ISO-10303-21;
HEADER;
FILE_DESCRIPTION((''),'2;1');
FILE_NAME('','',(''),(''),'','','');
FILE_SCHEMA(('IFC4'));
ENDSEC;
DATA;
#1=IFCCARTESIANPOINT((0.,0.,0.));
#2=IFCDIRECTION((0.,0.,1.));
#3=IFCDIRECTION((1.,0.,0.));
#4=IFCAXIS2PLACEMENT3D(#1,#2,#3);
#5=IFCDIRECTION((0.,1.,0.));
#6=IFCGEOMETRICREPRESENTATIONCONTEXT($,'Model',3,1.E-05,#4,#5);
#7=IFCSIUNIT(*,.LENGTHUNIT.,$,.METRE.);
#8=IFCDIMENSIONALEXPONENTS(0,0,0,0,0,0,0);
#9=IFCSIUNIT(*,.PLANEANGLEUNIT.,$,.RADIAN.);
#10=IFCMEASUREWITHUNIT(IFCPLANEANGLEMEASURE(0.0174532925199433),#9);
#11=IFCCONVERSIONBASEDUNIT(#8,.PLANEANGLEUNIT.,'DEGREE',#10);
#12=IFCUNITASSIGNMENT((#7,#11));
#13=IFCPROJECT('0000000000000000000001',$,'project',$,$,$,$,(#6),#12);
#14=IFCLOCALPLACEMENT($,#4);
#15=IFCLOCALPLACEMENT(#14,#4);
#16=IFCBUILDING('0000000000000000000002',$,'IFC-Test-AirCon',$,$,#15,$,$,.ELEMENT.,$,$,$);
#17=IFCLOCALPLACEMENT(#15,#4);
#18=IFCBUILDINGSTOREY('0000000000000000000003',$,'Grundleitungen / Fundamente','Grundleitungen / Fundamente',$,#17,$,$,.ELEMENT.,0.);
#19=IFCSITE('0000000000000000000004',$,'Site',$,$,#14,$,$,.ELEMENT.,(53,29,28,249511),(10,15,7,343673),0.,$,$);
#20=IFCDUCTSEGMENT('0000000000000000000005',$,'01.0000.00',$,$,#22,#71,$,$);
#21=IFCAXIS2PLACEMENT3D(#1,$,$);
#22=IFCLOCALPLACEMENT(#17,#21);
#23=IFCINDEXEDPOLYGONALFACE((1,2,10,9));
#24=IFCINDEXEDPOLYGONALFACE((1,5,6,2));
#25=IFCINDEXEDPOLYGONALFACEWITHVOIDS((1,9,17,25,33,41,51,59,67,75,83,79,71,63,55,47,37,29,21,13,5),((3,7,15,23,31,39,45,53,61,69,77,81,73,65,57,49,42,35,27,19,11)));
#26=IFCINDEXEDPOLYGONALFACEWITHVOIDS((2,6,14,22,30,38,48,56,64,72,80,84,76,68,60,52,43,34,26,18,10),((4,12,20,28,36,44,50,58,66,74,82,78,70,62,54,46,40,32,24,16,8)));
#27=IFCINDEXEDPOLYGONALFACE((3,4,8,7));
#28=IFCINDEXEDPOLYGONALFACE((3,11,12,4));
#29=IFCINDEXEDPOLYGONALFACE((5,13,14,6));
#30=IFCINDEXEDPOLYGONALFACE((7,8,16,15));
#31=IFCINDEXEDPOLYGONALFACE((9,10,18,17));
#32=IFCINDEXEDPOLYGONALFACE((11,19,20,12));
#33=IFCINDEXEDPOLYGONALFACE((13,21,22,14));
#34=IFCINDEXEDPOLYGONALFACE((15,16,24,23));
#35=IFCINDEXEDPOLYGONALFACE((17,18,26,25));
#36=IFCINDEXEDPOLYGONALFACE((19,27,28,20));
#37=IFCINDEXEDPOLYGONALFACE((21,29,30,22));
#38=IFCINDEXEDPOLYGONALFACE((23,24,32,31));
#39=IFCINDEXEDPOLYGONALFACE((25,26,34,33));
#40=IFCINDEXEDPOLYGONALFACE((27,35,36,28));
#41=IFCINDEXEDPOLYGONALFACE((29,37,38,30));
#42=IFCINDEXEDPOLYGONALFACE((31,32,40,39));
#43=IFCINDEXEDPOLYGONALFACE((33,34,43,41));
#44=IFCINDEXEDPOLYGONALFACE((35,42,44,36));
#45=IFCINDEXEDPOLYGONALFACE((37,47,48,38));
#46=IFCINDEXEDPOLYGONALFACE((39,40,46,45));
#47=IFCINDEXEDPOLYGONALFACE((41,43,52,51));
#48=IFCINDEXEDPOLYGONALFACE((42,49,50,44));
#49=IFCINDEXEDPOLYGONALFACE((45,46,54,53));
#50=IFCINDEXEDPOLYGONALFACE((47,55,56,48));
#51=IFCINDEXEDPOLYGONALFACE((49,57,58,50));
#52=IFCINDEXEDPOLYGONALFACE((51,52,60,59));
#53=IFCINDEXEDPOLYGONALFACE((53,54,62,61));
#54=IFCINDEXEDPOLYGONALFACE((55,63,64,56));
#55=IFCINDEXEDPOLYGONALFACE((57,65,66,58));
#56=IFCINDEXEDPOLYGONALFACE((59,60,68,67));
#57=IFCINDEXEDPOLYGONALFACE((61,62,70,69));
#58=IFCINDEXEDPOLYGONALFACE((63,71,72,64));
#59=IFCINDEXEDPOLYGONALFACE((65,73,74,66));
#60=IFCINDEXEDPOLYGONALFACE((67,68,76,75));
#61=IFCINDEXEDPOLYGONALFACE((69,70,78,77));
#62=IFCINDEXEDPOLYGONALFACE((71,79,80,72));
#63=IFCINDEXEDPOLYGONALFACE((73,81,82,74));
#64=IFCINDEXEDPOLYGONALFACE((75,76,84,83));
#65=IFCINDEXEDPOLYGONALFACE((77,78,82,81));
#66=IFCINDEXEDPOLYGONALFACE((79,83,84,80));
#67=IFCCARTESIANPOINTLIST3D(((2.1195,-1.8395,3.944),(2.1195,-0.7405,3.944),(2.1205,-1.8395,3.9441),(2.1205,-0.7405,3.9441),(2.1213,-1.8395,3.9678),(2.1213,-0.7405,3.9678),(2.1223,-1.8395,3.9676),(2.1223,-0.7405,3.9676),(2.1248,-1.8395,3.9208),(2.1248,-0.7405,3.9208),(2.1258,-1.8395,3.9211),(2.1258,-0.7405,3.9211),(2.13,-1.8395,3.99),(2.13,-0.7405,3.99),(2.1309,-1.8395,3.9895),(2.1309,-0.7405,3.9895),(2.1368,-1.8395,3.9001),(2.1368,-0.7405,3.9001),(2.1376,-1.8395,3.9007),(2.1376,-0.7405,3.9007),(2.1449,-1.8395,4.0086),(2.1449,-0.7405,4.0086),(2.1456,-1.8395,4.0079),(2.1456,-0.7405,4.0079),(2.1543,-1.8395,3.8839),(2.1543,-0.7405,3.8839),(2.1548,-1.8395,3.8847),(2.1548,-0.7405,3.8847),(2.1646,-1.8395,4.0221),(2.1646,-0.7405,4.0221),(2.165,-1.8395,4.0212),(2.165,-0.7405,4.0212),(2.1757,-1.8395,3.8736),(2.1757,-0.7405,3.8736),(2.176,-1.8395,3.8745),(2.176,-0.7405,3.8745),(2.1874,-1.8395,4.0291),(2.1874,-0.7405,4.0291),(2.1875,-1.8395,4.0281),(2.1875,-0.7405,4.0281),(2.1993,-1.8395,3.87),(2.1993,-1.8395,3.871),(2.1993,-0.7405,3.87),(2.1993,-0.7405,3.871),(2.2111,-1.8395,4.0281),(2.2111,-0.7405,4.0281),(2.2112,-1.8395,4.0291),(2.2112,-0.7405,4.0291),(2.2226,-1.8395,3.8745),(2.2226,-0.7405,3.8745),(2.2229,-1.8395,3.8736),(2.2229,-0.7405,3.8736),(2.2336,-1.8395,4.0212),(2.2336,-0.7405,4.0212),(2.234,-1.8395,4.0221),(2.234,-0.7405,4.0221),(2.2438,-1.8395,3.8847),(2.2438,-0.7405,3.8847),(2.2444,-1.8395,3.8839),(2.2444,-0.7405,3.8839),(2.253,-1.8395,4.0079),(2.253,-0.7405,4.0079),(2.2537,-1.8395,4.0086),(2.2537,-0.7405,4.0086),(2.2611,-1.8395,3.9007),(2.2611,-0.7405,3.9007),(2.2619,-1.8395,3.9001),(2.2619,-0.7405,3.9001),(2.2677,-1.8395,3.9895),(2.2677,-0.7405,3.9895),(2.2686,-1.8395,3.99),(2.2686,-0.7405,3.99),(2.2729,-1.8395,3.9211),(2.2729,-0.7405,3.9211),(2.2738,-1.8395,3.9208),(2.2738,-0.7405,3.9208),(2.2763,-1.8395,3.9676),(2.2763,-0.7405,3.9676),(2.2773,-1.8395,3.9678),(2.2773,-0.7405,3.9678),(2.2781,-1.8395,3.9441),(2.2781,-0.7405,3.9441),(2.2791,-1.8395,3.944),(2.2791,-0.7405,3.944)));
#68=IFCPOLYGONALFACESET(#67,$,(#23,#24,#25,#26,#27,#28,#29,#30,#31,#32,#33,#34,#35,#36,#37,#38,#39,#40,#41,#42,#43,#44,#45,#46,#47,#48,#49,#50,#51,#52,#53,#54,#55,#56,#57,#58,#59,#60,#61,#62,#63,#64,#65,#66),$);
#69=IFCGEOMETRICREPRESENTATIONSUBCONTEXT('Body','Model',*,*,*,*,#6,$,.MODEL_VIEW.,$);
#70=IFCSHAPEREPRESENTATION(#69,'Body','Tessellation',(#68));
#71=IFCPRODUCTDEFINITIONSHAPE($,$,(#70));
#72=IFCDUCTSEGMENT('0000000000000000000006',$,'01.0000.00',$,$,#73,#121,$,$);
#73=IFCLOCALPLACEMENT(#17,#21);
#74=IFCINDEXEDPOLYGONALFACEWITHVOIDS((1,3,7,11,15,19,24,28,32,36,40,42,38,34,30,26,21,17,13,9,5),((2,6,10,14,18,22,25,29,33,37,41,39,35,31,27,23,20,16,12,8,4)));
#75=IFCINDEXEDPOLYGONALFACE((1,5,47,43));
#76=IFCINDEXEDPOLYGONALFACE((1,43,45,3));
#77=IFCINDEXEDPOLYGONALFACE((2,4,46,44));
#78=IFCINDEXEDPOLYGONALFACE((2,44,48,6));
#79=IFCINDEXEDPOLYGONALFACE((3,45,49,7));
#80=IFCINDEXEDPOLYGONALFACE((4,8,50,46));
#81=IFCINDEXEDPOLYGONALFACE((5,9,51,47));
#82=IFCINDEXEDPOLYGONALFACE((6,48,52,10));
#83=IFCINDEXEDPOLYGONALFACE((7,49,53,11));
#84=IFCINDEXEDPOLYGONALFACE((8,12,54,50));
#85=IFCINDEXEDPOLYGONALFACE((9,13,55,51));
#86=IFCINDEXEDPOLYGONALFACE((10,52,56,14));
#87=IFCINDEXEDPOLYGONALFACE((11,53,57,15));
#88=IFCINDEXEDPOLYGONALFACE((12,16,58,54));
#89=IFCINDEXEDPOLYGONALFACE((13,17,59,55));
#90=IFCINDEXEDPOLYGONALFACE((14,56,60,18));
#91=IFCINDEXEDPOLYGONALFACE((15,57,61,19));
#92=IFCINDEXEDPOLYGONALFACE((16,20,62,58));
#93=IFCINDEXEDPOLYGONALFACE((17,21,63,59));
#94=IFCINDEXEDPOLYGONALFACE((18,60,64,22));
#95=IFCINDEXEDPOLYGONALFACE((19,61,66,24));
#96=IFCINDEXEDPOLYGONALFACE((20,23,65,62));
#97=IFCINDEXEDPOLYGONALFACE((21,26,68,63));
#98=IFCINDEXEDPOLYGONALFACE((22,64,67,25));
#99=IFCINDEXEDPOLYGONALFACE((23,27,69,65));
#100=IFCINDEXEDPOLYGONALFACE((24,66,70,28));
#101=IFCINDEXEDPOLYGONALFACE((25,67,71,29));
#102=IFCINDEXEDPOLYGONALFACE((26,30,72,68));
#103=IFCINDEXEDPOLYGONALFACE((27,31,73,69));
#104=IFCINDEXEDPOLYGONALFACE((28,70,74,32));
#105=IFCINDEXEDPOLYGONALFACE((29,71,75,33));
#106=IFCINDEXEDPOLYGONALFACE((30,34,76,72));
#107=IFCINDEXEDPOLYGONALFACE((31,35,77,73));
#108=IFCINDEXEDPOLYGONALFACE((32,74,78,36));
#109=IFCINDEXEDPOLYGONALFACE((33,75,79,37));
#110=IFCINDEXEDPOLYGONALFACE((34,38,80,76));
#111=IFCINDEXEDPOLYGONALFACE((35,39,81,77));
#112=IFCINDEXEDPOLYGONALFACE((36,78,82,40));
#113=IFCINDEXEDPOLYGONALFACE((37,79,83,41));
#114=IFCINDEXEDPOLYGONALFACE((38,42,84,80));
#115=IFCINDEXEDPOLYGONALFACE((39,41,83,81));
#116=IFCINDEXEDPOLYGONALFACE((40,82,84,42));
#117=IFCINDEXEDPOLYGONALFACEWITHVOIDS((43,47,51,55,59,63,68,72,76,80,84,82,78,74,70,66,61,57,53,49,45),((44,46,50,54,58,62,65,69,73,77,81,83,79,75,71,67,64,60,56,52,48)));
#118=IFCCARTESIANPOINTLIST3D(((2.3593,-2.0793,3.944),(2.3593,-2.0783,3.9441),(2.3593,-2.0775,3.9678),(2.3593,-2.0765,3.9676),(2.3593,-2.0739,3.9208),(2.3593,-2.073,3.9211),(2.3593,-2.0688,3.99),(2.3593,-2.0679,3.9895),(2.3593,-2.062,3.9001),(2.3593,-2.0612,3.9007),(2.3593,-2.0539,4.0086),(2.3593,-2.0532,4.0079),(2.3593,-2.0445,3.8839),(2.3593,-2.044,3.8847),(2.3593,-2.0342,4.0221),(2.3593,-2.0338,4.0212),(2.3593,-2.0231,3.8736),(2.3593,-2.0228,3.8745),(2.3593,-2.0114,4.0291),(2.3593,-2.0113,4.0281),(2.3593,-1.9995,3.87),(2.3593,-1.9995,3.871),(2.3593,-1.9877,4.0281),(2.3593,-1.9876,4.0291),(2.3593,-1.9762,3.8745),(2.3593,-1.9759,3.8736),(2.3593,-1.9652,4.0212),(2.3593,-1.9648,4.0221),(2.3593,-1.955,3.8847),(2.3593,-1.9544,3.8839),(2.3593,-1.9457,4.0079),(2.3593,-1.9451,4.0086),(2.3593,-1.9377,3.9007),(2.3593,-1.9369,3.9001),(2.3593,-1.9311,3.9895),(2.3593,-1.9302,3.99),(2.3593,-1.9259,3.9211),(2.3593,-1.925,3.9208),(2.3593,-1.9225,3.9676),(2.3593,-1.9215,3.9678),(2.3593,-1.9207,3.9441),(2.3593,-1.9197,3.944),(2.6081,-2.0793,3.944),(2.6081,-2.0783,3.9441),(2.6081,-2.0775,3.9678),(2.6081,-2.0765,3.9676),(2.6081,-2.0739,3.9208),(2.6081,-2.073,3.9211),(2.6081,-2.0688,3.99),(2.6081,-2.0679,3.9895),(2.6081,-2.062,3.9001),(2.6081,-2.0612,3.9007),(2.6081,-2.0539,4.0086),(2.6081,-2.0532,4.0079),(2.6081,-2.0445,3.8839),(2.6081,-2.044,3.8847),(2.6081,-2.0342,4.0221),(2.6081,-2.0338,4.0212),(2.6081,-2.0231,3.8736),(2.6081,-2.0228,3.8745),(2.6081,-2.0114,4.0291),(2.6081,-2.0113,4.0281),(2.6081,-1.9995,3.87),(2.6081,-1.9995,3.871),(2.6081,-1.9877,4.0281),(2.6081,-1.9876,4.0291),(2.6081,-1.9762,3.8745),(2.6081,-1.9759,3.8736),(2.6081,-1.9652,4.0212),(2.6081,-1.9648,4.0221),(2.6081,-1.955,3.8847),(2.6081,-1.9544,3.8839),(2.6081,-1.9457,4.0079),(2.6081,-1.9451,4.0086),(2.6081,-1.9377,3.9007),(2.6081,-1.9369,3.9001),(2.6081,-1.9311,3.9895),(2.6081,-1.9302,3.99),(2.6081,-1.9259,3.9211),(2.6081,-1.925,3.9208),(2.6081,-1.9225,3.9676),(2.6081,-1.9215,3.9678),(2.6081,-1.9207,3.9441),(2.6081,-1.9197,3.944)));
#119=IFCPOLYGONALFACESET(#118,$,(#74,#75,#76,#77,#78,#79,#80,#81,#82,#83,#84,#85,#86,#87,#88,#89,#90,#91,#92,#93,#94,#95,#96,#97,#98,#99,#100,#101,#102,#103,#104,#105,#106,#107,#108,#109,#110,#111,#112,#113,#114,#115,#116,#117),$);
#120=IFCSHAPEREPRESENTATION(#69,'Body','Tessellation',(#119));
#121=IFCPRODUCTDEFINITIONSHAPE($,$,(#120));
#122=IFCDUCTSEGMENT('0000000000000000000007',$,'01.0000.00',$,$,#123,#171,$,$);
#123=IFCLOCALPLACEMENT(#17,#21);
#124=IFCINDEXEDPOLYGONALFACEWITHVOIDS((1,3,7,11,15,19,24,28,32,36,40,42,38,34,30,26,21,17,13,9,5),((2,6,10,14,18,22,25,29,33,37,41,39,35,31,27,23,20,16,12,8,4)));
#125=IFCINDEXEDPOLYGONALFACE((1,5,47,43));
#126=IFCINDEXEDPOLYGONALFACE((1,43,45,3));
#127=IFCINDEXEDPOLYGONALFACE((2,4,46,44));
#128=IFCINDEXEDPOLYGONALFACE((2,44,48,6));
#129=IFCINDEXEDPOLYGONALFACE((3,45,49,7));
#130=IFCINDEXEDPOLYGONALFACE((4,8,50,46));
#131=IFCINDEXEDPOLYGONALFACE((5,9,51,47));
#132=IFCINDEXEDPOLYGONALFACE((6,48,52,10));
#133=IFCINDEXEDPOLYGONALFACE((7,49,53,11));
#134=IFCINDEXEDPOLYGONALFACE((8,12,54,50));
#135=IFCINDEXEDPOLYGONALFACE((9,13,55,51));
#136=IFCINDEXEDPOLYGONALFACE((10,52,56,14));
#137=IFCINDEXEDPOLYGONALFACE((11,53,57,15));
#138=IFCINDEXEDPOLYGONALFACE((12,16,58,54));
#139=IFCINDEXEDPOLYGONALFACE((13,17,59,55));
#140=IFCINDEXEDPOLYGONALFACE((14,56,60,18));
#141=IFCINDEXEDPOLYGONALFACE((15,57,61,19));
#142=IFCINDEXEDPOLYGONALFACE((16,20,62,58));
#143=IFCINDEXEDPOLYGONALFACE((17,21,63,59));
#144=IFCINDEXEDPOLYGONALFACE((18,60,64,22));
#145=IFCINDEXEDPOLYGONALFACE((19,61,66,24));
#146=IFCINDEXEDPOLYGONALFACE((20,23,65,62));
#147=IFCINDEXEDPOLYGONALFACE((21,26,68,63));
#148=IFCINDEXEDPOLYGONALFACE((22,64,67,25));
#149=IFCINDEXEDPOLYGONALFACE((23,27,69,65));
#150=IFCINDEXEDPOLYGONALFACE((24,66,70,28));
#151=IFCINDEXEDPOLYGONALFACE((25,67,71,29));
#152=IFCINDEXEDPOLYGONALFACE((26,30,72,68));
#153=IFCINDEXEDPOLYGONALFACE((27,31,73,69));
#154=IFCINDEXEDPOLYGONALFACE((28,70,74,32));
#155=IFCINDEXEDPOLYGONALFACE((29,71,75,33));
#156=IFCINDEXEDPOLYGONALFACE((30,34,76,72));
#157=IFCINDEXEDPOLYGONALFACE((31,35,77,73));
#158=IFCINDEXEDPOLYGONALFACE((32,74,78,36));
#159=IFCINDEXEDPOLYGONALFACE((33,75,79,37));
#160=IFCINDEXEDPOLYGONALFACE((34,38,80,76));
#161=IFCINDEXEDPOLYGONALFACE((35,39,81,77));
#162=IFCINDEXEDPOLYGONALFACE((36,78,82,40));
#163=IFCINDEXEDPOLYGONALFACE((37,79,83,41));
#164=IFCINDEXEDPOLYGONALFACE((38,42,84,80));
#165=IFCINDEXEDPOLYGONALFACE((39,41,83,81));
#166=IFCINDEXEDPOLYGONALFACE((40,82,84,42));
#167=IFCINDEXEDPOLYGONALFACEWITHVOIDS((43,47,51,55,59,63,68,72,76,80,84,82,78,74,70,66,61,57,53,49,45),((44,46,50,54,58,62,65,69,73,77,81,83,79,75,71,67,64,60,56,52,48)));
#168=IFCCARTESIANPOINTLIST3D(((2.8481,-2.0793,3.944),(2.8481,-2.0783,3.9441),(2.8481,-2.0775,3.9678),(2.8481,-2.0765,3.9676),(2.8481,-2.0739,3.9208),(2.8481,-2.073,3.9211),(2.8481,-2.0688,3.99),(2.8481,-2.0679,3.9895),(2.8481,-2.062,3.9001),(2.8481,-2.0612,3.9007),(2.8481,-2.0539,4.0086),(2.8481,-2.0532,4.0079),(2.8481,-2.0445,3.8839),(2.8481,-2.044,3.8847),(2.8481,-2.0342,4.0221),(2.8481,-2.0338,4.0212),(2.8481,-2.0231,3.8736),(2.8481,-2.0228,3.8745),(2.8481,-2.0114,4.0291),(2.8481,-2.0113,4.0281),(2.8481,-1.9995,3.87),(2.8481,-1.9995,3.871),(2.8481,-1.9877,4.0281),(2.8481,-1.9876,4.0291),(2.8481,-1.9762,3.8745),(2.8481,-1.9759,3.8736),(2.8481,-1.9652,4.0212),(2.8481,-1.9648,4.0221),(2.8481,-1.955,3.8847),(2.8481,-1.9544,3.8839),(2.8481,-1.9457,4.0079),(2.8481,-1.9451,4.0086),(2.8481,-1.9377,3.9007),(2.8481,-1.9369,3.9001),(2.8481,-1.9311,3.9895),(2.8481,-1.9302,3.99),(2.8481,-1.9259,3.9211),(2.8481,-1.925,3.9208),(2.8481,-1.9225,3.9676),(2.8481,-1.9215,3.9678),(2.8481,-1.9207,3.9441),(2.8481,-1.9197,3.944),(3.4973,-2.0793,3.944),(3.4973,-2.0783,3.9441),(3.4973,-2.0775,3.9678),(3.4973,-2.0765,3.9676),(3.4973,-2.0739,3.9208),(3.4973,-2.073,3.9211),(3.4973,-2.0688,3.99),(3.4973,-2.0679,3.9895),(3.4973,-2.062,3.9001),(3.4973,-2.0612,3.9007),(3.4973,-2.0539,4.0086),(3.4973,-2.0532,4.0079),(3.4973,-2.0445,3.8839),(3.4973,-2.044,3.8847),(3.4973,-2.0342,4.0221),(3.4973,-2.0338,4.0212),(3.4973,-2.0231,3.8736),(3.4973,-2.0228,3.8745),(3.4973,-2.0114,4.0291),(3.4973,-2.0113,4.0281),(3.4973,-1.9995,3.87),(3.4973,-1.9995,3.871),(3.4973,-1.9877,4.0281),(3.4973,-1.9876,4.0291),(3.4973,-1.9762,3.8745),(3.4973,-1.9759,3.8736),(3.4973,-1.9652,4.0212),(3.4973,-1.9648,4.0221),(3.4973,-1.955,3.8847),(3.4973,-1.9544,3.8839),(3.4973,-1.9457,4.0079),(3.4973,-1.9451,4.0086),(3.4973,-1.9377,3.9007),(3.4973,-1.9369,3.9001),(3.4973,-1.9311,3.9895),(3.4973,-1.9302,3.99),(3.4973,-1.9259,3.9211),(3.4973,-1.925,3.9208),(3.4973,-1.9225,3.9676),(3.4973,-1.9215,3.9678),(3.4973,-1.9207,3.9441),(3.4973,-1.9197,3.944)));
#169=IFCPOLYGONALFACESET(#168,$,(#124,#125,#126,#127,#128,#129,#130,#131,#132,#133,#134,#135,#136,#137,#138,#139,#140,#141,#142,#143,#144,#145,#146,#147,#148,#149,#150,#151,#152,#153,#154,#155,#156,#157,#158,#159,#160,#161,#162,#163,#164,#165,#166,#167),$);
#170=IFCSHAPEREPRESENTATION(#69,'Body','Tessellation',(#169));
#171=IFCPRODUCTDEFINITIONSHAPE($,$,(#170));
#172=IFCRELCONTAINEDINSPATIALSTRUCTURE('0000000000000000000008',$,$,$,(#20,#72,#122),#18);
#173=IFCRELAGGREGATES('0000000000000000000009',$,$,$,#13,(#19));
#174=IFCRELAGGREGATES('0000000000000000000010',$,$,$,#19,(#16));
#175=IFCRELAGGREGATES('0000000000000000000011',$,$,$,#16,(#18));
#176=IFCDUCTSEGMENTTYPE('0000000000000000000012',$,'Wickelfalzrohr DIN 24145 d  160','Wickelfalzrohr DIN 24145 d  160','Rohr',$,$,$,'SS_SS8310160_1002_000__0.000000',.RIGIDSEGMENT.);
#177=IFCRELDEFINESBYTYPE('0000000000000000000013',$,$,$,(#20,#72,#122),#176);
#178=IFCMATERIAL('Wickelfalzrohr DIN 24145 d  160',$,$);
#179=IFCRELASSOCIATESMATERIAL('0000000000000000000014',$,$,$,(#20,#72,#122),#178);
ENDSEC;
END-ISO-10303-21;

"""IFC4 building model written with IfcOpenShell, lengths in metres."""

from ifc_helpers import new_model, entity, si_unit, converted_unit, direction, frame, origin_with_axes, origin_2d_with_axis, place, context, subcontext, project, spatial, hollow_circle, extrude, material, type_object, element, save


model = new_model("IFC4")

# Units and contexts
model_context = context("Model", 3, precision=1e-05, world=origin_with_axes(), true_north=direction((0.0, 1.0, 0.0)))
body_context = subcontext(model_context, "Body", "Model", "MODEL_VIEW")
ifc_project = project(units=[si_unit("LENGTHUNIT", "METRE"), converted_unit("PLANEANGLEUNIT", "DEGREE", entity("IfcPlaneAngleMeasure", 0.0174532925199433), si_unit("PLANEANGLEUNIT", "RADIAN"), dimensions=[0, 0, 0, 0, 0, 0, 0])], contexts=[model_context])

# Site, building, storey
site_placement = place(None, origin_with_axes())
site = spatial("IfcSite", under=ifc_project, at=site_placement, Name="Site", CompositionType="ELEMENT", RefLatitude=(53, 29, 28, 249511), RefLongitude=(10, 15, 7, 343673), RefElevation=0.0)
building_placement = place(site_placement, origin_with_axes())
building = spatial("IfcBuilding", under=site, at=building_placement, Name="IFC-Test-AirCon", CompositionType="ELEMENT")
storey_placement = place(building_placement, origin_with_axes())
storey = spatial("IfcBuildingStorey", under=building, at=storey_placement, Name="Grundleitungen / Fundamente", Description="Grundleitungen / Fundamente", CompositionType="ELEMENT", Elevation=0.0)

# Duct segments
ifc_material_1 = material(Name="Wickelfalzrohr DIN 24145 d  160")
duct_segment_type_1 = type_object("IfcDuctSegmentType", Name="Wickelfalzrohr DIN 24145 d  160", Description="Wickelfalzrohr DIN 24145 d  160", ApplicableOccurrence="Rohr", ElementType="SS_SS8310160_1002_000__0.000000", PredefinedType="RIGIDSEGMENT")
duct_segment_1_placement = place(storey_placement, frame((2.1993, -0.7405, 3.95), z_axis=(0.0, 0.0, 1.0), x_axis=(0.0, -1.0, 0.0)))
element("IfcDuctSegment", 1, at=duct_segment_1_placement, inside=storey, type_object=duct_segment_type_1, material=ifc_material_1, Name="01.0000.00", context=body_context, shape_type="SweptSolid", body=[
    extrude(hollow_circle(Radius=0.08, WallThickness=0.001, at=origin_2d_with_axis()), frame((0.0, 0.0, 0.0), z_axis=(1.0, 0.0, 0.0), x_axis=(0.0, 0.0, -1.0)), (0.0, 0.0, 1.0), 1.099),
])
duct_segment_2_placement = place(storey_placement, frame((2.3593, -1.9995, 3.95), z_axis=(0.0, 0.0, 1.0), x_axis=(1.0, 0.0, 0.0)))
element("IfcDuctSegment", 2, at=duct_segment_2_placement, inside=storey, type_object=duct_segment_type_1, material=ifc_material_1, Name="01.0000.00", context=body_context, shape_type="SweptSolid", body=[
    extrude(hollow_circle(Radius=0.08, WallThickness=0.001, at=origin_2d_with_axis()), frame((0.0, 0.0, 0.0), z_axis=(1.0, 0.0, 0.0), x_axis=(0.0, 0.0, -1.0)), (0.0, 0.0, 1.0), 0.2488),
])
duct_segment_3_placement = place(storey_placement, frame((2.8481, -1.9995, 3.95), z_axis=(0.0, 0.0, 1.0), x_axis=(1.0, 0.0, 0.0)))
element("IfcDuctSegment", 3, at=duct_segment_3_placement, inside=storey, type_object=duct_segment_type_1, material=ifc_material_1, Name="01.0000.00", context=body_context, shape_type="SweptSolid", body=[
    extrude(hollow_circle(Radius=0.08, WallThickness=0.001, at=origin_2d_with_axis()), frame((0.0, 0.0, 0.0), z_axis=(1.0, 0.0, 0.0), x_axis=(0.0, 0.0, -1.0)), (0.0, 0.0, 1.0), 0.6492),
])

save(model, "model.ifc")
